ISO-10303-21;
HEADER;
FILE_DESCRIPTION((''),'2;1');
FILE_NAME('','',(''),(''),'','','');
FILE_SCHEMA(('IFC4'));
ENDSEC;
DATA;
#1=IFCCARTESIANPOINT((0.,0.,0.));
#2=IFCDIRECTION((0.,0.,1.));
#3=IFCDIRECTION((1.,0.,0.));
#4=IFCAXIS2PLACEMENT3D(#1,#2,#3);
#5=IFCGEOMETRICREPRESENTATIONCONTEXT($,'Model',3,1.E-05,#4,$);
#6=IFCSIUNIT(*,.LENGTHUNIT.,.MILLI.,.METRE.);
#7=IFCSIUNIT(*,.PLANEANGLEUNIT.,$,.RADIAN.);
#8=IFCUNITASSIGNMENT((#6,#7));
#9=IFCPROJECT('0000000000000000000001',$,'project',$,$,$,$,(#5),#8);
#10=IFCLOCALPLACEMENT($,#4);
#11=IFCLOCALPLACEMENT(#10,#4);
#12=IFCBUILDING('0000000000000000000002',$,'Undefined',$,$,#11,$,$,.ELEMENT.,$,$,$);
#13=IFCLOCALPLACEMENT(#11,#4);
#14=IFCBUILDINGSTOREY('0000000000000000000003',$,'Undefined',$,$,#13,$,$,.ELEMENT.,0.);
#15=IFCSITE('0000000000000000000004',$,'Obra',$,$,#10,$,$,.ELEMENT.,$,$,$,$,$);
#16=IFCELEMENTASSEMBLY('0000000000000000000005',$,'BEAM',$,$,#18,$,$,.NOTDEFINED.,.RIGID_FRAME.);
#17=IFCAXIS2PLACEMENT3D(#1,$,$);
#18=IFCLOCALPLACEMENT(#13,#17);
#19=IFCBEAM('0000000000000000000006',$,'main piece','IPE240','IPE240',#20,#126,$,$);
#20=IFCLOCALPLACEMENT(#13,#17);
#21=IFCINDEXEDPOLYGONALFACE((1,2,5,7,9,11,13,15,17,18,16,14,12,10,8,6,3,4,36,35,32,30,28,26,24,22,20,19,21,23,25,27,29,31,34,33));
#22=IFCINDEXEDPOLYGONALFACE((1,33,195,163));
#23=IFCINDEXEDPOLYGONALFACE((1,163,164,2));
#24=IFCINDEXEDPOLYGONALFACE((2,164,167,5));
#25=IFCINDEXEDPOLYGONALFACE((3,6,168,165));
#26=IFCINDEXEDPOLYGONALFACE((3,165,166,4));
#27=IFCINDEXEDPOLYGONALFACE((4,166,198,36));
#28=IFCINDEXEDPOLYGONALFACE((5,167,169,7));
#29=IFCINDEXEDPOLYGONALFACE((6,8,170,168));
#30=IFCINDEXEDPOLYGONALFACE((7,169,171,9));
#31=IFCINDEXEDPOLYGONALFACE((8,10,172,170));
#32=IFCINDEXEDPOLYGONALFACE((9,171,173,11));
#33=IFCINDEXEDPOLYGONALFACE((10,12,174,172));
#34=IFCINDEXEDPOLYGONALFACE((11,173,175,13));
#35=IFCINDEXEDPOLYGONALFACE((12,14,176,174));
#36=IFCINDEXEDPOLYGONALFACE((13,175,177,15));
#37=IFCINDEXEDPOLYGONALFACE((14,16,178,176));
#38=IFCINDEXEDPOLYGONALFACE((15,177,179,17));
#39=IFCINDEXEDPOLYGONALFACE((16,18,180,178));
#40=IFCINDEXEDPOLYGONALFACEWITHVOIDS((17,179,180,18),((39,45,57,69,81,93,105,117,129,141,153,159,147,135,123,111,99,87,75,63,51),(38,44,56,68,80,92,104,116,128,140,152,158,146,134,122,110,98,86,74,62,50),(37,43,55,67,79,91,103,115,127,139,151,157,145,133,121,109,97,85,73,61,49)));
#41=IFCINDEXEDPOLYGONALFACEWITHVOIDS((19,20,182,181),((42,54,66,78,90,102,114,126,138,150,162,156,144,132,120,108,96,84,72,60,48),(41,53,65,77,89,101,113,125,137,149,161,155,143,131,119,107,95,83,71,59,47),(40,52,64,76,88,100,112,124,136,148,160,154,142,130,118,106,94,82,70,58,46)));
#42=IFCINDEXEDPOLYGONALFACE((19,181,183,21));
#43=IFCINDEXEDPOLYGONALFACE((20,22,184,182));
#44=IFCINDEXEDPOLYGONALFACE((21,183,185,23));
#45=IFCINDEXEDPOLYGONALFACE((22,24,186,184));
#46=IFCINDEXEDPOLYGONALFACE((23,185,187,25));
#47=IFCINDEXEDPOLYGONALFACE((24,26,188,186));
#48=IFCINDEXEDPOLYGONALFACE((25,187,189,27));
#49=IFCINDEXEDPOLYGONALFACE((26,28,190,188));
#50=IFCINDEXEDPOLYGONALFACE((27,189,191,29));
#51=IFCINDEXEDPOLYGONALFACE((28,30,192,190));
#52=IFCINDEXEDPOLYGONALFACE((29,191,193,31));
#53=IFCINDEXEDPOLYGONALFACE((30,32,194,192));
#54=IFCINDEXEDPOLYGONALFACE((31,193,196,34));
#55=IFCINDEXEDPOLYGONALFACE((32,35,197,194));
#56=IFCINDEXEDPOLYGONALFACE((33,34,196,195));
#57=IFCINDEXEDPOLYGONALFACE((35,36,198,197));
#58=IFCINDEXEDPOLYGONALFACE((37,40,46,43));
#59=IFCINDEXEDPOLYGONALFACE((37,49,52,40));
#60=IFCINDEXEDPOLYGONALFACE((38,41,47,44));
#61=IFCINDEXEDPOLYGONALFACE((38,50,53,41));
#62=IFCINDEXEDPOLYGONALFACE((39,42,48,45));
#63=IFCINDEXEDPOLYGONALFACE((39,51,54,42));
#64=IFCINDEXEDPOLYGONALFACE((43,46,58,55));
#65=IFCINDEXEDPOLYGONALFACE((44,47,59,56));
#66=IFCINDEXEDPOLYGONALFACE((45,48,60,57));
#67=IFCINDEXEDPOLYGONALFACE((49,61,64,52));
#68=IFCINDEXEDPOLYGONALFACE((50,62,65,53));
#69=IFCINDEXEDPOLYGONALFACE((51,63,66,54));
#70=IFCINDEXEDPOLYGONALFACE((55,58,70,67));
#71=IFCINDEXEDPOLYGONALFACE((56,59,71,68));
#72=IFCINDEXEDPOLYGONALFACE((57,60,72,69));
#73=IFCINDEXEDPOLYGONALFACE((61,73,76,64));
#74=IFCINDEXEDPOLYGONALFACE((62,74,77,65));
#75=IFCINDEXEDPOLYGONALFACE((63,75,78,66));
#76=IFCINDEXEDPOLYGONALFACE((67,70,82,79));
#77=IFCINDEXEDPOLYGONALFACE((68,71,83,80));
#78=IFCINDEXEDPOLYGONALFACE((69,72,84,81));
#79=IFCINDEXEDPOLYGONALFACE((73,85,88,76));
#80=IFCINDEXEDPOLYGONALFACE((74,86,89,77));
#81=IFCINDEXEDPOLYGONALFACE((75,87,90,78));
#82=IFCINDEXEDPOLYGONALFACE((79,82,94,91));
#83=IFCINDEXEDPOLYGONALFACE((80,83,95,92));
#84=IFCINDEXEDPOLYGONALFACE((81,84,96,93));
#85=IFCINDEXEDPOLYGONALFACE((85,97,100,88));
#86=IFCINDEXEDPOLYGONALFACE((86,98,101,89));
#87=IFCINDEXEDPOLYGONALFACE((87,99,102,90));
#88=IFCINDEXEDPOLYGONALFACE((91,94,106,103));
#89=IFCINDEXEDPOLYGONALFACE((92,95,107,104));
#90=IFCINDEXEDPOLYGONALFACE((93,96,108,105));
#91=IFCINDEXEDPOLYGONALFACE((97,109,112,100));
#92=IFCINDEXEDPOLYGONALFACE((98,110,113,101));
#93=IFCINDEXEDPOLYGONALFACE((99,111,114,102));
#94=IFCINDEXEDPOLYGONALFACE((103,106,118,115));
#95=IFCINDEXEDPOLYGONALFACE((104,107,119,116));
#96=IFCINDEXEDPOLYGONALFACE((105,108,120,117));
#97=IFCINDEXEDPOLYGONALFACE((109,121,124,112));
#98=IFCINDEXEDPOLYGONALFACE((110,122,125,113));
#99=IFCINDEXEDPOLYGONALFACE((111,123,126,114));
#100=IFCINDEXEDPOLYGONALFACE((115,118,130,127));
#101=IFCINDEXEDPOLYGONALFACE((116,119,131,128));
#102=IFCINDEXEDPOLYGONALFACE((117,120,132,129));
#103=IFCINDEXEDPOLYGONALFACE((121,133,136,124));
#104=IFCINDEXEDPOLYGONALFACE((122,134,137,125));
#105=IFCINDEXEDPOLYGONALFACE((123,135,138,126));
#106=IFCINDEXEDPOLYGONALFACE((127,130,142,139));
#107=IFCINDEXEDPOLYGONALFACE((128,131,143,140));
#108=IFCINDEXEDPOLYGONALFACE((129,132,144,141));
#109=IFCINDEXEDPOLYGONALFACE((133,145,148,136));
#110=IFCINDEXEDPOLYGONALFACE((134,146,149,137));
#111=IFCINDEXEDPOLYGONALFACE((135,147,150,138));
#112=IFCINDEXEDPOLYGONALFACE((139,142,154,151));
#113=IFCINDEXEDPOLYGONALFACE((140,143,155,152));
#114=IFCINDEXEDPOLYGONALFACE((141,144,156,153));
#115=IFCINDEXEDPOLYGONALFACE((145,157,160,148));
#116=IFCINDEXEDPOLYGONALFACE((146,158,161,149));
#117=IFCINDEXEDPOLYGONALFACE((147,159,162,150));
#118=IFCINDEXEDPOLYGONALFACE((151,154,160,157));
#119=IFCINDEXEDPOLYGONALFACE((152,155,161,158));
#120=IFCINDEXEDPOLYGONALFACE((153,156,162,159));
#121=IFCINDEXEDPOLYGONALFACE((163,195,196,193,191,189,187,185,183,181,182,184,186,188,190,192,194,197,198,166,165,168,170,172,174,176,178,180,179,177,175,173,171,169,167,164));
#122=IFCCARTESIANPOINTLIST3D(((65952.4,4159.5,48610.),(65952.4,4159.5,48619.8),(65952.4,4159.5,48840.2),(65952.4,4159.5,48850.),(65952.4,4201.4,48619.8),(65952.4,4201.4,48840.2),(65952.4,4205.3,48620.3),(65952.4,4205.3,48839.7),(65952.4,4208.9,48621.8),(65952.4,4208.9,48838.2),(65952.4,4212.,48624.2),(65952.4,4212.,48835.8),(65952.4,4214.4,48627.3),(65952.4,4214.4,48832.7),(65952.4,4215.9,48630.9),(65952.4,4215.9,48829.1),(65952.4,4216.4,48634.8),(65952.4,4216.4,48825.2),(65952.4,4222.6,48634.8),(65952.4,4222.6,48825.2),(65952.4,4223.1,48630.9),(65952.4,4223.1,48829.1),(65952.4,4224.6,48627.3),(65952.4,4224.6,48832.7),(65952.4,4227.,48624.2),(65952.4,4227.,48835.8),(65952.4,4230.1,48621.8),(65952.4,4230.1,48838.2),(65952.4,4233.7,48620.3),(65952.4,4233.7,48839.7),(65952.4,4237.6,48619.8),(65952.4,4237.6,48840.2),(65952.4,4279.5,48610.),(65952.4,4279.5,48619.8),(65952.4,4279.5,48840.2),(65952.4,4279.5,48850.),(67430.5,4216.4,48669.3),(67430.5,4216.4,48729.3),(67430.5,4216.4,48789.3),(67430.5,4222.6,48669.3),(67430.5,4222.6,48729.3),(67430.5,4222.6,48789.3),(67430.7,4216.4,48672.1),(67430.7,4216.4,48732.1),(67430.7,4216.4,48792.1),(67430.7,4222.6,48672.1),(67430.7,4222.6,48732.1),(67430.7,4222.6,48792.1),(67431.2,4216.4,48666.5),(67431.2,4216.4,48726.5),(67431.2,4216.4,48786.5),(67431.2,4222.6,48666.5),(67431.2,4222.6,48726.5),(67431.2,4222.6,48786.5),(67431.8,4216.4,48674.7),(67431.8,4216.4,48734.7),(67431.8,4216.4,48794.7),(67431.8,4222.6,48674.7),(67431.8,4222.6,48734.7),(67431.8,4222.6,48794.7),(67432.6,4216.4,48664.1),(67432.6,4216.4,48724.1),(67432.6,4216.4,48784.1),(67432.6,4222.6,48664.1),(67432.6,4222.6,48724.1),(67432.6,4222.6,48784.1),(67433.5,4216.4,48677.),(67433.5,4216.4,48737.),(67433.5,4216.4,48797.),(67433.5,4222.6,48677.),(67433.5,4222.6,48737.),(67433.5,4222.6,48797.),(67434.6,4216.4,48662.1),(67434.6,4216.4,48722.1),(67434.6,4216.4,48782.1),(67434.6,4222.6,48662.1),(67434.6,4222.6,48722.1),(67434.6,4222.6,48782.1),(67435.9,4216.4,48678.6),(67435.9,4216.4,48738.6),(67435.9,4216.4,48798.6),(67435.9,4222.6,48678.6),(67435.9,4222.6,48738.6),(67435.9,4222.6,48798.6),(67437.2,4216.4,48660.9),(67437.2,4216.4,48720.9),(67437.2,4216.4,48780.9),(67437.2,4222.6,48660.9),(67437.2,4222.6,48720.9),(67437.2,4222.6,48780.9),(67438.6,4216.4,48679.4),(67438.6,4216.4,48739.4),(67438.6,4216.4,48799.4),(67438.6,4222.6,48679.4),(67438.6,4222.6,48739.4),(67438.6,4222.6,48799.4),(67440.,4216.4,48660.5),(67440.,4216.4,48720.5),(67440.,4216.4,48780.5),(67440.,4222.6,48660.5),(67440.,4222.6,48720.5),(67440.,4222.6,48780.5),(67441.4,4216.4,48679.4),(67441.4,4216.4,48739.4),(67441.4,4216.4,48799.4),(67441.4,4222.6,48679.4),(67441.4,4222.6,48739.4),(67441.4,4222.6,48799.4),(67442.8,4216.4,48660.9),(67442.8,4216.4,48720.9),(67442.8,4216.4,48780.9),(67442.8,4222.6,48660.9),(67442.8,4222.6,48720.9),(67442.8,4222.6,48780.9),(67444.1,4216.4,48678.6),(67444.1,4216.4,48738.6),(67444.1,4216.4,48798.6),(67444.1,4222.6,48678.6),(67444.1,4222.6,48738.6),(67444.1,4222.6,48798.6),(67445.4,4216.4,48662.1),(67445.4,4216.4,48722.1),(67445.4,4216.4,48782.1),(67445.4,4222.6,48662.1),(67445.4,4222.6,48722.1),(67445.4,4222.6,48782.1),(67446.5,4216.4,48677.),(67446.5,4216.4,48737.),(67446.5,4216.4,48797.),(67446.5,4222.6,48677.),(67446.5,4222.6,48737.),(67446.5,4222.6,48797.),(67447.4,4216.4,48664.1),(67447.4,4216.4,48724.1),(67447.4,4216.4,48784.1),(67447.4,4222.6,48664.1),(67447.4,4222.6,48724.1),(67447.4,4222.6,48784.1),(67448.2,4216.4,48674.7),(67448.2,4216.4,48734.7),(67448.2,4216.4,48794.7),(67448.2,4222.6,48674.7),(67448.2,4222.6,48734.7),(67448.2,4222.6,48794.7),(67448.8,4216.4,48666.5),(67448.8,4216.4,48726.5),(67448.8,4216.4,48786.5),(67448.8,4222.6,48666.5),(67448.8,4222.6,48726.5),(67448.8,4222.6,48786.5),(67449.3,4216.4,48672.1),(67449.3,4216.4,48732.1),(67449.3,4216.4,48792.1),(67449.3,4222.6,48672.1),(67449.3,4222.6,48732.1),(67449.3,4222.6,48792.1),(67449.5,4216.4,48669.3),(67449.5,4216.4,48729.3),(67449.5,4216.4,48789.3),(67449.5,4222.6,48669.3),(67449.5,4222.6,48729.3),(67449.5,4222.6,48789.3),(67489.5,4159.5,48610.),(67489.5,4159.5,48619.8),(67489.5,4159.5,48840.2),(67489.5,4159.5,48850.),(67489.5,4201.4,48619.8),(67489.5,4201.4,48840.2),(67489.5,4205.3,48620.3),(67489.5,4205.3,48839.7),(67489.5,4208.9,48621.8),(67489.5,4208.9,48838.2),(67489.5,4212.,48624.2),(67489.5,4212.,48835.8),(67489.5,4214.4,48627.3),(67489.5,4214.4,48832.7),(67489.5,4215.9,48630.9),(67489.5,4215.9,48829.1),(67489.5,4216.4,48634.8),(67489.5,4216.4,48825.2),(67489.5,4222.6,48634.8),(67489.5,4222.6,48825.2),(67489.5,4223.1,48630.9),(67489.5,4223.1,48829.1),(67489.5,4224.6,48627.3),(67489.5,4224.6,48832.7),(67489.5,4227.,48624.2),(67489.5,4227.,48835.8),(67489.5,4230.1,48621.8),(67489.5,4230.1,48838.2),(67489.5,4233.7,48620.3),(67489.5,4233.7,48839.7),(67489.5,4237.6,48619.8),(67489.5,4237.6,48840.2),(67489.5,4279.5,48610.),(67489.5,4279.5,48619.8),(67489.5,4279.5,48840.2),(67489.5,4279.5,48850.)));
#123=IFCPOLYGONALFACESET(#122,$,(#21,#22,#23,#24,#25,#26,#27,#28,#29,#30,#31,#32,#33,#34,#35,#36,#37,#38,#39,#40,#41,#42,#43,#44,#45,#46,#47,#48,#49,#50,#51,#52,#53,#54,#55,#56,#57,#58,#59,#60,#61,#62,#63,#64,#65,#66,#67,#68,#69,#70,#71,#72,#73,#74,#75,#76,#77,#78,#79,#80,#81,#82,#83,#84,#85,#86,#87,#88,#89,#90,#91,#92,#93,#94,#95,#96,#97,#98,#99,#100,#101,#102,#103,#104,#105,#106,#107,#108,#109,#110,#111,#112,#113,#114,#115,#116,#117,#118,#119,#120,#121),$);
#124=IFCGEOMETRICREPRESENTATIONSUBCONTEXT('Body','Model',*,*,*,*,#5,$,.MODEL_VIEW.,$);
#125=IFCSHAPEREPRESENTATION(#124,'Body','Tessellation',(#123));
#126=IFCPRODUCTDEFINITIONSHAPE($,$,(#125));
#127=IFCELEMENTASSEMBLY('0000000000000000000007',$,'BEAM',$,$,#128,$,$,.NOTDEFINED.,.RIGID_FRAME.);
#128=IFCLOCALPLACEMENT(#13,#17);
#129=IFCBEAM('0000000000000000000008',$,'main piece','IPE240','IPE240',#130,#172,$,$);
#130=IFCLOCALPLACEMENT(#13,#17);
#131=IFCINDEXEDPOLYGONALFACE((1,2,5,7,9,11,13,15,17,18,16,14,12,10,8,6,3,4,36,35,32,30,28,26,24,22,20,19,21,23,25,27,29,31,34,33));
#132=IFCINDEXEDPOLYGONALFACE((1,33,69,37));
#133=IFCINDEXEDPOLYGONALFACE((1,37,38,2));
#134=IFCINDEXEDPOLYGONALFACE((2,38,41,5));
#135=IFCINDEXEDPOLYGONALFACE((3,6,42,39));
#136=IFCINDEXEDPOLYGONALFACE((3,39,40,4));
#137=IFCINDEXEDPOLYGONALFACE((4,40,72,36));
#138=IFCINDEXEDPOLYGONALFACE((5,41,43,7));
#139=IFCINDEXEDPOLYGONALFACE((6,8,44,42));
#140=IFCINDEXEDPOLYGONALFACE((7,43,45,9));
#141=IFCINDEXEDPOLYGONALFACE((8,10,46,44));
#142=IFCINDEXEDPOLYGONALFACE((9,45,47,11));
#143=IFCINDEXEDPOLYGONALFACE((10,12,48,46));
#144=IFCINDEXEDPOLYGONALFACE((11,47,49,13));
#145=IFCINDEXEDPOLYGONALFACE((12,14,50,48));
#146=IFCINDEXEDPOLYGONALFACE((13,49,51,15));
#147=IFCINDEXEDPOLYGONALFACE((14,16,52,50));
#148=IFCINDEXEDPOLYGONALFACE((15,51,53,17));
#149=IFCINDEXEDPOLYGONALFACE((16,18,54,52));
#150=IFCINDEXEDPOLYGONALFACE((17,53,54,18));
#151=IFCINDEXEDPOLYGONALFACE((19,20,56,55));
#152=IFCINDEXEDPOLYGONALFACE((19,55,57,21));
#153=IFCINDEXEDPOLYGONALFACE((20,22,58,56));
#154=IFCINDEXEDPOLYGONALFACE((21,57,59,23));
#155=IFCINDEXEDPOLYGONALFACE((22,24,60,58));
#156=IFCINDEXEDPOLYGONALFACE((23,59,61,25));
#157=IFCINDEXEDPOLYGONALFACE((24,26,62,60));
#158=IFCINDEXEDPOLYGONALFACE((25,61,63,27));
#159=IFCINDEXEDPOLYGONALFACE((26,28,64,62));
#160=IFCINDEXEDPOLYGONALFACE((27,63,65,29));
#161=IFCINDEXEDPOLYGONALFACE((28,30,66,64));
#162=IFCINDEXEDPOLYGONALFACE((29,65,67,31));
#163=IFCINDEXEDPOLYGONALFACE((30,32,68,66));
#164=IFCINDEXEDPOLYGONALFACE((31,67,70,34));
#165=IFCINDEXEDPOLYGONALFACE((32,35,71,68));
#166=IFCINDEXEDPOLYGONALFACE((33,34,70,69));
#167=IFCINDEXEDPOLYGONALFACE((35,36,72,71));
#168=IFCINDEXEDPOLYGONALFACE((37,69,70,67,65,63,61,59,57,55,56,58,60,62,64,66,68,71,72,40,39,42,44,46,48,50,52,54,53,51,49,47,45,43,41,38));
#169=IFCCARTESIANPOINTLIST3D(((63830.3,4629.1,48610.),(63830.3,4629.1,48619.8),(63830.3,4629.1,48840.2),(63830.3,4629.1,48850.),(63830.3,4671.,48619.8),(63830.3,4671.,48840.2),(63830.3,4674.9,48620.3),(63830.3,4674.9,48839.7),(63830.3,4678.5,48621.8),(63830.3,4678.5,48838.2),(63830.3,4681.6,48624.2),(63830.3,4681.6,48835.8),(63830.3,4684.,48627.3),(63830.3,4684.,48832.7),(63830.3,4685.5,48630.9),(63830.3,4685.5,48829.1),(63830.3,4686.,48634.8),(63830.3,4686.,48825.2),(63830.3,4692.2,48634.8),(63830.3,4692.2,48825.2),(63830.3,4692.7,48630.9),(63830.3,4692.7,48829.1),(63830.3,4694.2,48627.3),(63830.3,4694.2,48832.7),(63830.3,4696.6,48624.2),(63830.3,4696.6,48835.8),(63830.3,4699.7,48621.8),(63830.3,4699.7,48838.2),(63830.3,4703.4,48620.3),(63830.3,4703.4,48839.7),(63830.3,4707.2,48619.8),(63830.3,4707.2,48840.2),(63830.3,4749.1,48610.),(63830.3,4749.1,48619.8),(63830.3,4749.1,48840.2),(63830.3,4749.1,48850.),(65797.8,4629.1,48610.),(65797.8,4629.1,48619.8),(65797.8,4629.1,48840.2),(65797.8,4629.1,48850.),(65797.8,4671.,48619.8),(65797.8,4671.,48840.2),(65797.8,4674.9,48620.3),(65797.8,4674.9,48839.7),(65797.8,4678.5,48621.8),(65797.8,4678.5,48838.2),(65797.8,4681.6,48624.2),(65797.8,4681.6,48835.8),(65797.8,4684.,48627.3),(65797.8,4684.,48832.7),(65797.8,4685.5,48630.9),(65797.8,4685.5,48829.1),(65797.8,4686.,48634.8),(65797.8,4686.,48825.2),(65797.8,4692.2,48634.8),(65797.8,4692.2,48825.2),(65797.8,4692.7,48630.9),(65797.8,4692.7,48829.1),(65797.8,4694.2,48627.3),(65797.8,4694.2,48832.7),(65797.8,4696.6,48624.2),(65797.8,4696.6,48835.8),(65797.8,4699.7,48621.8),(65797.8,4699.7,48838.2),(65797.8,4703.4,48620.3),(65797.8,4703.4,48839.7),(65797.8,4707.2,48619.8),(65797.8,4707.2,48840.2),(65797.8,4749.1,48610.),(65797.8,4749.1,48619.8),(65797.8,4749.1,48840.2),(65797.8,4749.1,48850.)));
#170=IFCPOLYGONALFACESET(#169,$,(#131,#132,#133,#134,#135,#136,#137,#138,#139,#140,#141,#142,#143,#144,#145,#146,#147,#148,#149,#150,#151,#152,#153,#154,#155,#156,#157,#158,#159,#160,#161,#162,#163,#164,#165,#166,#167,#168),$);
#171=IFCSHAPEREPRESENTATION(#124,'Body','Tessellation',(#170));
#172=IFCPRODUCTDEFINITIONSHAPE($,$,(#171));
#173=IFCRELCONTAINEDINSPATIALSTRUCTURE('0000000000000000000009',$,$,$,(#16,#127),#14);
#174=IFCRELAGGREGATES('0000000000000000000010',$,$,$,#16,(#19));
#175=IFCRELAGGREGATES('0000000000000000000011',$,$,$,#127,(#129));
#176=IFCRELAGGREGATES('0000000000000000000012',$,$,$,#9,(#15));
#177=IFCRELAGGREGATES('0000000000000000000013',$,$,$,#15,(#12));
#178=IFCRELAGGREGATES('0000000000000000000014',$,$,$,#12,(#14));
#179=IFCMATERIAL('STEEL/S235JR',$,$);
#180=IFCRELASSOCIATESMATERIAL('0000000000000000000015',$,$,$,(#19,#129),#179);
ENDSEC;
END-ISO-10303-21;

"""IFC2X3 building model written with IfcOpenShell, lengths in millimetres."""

from ifc_helpers import new_model, si_unit, frame, origin_with_axes, origin_2d_with_axis, place, context, subcontext, project, spatial, circle, i_section, extrude, clip, halfspace, source, transform, mapped, material, element, aggregate, save


model = new_model("IFC2X3")

# Units and contexts
model_context = context("Model", 3, precision=1e-05, world=origin_with_axes())
body_context = subcontext(model_context, "Body", "Model", "MODEL_VIEW")
ifc_project = project(units=[si_unit("LENGTHUNIT", "METRE", prefix="MILLI"), si_unit("PLANEANGLEUNIT", "RADIAN")], contexts=[model_context])

# Site, building, storey
site_placement = place(None, origin_with_axes())
site = spatial("IfcSite", under=ifc_project, at=site_placement, Name="Obra", CompositionType="ELEMENT")
building_placement = place(site_placement, origin_with_axes())
building = spatial("IfcBuilding", under=site, at=building_placement, Name="Undefined", CompositionType="ELEMENT")
storey_placement = place(building_placement, origin_with_axes())
storey = spatial("IfcBuildingStorey", under=building, at=storey_placement, Name="Undefined", CompositionType="ELEMENT", Elevation=0.0)

# Shared definitions
ifc_material_1 = material(Name="STEEL/S235JR")

# Element assembly, beam, opening
shared_shape_1 = source(origin_with_axes(), body_context, "Body", "SweptSolid", [
    extrude(circle(Radius=9.5, at=origin_2d_with_axis()), frame((0.0, -3.2, 0.0), z_axis=(0.0, 1.0, 0.0), x_axis=(1.0, 0.0, 0.0)), (0.0, 0.0, 1.0), 6.4),
])
assembly_1_placement = place(storey_placement, origin_with_axes())
assembly_1 = element("IfcElementAssembly", 1, at=assembly_1_placement, inside=storey, Name="BEAM", AssemblyPlace="NOTDEFINED", PredefinedType="RIGID_FRAME")
beam_1_placement = place(assembly_1_placement, frame((65952.4, 4219.5, 48730.0), z_axis=(0.0, 0.0, 1.0), x_axis=(1.0, 0.0, 0.0)))
beam_1 = element("IfcBeam", 2, at=beam_1_placement, material=ifc_material_1, Name="main piece", Description="IPE240", ObjectType="IPE240", context=body_context, shape_type="Clipping", body=[
    clip(extrude(i_section(OverallWidth=120.0, OverallDepth=240.0, WebThickness=6.2, FlangeThickness=9.8, FilletRadius=15.0, at=origin_2d_with_axis()), frame((1741.1, 0.0, 0.0), z_axis=(-1.0, 0.0, 0.0), x_axis=(0.0, -1.0, 0.0)), (0.0, 0.0, 1.0), 1741.1), halfspace(frame((1537.1, -60.0, -120.0), z_axis=(1.0, 0.000019, 0.0), x_axis=(0.0, 0.0, 1.0)), False)),
])
opening_1_placement = place(assembly_1_placement, frame((67490.0, 4219.5, 48850.0), z_axis=(-1.0, 0.0, 0.0), x_axis=(0.0, 0.0, -1.0)))
element("IfcOpeningElement", 3, at=opening_1_placement, cuts=beam_1, ObjectType="Opening", context=body_context, shape_type="MappedRepresentation", body=[
    mapped(shared_shape_1, transform((60.0, 0.0, 50.0))),
    mapped(shared_shape_1, transform((120.0, 0.0, 50.0))),
    mapped(shared_shape_1, transform((180.0, 0.0, 50.0))),
])
aggregate(assembly_1, [beam_1])

# Element assembly, beam
assembly_2_placement = place(storey_placement, origin_with_axes())
assembly_2 = element("IfcElementAssembly", 4, at=assembly_2_placement, inside=storey, Name="BEAM", AssemblyPlace="NOTDEFINED", PredefinedType="RIGID_FRAME")
beam_2_placement = place(assembly_2_placement, frame((65797.8, 4689.1, 48730.0), z_axis=(0.0, 0.0, 1.0), x_axis=(-1.0, 0.0, 0.0)))
beam_2 = element("IfcBeam", 5, at=beam_2_placement, material=ifc_material_1, Name="main piece", Description="IPE240", ObjectType="IPE240", context=body_context, shape_type="SweptSolid", body=[
    extrude(i_section(OverallWidth=120.0, OverallDepth=240.0, WebThickness=6.2, FlangeThickness=9.8, FilletRadius=15.0, at=origin_2d_with_axis()), frame((1967.5, 0.0, 0.0), z_axis=(-1.0, 0.0, 0.0), x_axis=(0.0, -1.0, 0.0)), (0.0, 0.0, 1.0), 1967.5),
])
aggregate(assembly_2, [beam_2])

save(model, "model.ifc")
